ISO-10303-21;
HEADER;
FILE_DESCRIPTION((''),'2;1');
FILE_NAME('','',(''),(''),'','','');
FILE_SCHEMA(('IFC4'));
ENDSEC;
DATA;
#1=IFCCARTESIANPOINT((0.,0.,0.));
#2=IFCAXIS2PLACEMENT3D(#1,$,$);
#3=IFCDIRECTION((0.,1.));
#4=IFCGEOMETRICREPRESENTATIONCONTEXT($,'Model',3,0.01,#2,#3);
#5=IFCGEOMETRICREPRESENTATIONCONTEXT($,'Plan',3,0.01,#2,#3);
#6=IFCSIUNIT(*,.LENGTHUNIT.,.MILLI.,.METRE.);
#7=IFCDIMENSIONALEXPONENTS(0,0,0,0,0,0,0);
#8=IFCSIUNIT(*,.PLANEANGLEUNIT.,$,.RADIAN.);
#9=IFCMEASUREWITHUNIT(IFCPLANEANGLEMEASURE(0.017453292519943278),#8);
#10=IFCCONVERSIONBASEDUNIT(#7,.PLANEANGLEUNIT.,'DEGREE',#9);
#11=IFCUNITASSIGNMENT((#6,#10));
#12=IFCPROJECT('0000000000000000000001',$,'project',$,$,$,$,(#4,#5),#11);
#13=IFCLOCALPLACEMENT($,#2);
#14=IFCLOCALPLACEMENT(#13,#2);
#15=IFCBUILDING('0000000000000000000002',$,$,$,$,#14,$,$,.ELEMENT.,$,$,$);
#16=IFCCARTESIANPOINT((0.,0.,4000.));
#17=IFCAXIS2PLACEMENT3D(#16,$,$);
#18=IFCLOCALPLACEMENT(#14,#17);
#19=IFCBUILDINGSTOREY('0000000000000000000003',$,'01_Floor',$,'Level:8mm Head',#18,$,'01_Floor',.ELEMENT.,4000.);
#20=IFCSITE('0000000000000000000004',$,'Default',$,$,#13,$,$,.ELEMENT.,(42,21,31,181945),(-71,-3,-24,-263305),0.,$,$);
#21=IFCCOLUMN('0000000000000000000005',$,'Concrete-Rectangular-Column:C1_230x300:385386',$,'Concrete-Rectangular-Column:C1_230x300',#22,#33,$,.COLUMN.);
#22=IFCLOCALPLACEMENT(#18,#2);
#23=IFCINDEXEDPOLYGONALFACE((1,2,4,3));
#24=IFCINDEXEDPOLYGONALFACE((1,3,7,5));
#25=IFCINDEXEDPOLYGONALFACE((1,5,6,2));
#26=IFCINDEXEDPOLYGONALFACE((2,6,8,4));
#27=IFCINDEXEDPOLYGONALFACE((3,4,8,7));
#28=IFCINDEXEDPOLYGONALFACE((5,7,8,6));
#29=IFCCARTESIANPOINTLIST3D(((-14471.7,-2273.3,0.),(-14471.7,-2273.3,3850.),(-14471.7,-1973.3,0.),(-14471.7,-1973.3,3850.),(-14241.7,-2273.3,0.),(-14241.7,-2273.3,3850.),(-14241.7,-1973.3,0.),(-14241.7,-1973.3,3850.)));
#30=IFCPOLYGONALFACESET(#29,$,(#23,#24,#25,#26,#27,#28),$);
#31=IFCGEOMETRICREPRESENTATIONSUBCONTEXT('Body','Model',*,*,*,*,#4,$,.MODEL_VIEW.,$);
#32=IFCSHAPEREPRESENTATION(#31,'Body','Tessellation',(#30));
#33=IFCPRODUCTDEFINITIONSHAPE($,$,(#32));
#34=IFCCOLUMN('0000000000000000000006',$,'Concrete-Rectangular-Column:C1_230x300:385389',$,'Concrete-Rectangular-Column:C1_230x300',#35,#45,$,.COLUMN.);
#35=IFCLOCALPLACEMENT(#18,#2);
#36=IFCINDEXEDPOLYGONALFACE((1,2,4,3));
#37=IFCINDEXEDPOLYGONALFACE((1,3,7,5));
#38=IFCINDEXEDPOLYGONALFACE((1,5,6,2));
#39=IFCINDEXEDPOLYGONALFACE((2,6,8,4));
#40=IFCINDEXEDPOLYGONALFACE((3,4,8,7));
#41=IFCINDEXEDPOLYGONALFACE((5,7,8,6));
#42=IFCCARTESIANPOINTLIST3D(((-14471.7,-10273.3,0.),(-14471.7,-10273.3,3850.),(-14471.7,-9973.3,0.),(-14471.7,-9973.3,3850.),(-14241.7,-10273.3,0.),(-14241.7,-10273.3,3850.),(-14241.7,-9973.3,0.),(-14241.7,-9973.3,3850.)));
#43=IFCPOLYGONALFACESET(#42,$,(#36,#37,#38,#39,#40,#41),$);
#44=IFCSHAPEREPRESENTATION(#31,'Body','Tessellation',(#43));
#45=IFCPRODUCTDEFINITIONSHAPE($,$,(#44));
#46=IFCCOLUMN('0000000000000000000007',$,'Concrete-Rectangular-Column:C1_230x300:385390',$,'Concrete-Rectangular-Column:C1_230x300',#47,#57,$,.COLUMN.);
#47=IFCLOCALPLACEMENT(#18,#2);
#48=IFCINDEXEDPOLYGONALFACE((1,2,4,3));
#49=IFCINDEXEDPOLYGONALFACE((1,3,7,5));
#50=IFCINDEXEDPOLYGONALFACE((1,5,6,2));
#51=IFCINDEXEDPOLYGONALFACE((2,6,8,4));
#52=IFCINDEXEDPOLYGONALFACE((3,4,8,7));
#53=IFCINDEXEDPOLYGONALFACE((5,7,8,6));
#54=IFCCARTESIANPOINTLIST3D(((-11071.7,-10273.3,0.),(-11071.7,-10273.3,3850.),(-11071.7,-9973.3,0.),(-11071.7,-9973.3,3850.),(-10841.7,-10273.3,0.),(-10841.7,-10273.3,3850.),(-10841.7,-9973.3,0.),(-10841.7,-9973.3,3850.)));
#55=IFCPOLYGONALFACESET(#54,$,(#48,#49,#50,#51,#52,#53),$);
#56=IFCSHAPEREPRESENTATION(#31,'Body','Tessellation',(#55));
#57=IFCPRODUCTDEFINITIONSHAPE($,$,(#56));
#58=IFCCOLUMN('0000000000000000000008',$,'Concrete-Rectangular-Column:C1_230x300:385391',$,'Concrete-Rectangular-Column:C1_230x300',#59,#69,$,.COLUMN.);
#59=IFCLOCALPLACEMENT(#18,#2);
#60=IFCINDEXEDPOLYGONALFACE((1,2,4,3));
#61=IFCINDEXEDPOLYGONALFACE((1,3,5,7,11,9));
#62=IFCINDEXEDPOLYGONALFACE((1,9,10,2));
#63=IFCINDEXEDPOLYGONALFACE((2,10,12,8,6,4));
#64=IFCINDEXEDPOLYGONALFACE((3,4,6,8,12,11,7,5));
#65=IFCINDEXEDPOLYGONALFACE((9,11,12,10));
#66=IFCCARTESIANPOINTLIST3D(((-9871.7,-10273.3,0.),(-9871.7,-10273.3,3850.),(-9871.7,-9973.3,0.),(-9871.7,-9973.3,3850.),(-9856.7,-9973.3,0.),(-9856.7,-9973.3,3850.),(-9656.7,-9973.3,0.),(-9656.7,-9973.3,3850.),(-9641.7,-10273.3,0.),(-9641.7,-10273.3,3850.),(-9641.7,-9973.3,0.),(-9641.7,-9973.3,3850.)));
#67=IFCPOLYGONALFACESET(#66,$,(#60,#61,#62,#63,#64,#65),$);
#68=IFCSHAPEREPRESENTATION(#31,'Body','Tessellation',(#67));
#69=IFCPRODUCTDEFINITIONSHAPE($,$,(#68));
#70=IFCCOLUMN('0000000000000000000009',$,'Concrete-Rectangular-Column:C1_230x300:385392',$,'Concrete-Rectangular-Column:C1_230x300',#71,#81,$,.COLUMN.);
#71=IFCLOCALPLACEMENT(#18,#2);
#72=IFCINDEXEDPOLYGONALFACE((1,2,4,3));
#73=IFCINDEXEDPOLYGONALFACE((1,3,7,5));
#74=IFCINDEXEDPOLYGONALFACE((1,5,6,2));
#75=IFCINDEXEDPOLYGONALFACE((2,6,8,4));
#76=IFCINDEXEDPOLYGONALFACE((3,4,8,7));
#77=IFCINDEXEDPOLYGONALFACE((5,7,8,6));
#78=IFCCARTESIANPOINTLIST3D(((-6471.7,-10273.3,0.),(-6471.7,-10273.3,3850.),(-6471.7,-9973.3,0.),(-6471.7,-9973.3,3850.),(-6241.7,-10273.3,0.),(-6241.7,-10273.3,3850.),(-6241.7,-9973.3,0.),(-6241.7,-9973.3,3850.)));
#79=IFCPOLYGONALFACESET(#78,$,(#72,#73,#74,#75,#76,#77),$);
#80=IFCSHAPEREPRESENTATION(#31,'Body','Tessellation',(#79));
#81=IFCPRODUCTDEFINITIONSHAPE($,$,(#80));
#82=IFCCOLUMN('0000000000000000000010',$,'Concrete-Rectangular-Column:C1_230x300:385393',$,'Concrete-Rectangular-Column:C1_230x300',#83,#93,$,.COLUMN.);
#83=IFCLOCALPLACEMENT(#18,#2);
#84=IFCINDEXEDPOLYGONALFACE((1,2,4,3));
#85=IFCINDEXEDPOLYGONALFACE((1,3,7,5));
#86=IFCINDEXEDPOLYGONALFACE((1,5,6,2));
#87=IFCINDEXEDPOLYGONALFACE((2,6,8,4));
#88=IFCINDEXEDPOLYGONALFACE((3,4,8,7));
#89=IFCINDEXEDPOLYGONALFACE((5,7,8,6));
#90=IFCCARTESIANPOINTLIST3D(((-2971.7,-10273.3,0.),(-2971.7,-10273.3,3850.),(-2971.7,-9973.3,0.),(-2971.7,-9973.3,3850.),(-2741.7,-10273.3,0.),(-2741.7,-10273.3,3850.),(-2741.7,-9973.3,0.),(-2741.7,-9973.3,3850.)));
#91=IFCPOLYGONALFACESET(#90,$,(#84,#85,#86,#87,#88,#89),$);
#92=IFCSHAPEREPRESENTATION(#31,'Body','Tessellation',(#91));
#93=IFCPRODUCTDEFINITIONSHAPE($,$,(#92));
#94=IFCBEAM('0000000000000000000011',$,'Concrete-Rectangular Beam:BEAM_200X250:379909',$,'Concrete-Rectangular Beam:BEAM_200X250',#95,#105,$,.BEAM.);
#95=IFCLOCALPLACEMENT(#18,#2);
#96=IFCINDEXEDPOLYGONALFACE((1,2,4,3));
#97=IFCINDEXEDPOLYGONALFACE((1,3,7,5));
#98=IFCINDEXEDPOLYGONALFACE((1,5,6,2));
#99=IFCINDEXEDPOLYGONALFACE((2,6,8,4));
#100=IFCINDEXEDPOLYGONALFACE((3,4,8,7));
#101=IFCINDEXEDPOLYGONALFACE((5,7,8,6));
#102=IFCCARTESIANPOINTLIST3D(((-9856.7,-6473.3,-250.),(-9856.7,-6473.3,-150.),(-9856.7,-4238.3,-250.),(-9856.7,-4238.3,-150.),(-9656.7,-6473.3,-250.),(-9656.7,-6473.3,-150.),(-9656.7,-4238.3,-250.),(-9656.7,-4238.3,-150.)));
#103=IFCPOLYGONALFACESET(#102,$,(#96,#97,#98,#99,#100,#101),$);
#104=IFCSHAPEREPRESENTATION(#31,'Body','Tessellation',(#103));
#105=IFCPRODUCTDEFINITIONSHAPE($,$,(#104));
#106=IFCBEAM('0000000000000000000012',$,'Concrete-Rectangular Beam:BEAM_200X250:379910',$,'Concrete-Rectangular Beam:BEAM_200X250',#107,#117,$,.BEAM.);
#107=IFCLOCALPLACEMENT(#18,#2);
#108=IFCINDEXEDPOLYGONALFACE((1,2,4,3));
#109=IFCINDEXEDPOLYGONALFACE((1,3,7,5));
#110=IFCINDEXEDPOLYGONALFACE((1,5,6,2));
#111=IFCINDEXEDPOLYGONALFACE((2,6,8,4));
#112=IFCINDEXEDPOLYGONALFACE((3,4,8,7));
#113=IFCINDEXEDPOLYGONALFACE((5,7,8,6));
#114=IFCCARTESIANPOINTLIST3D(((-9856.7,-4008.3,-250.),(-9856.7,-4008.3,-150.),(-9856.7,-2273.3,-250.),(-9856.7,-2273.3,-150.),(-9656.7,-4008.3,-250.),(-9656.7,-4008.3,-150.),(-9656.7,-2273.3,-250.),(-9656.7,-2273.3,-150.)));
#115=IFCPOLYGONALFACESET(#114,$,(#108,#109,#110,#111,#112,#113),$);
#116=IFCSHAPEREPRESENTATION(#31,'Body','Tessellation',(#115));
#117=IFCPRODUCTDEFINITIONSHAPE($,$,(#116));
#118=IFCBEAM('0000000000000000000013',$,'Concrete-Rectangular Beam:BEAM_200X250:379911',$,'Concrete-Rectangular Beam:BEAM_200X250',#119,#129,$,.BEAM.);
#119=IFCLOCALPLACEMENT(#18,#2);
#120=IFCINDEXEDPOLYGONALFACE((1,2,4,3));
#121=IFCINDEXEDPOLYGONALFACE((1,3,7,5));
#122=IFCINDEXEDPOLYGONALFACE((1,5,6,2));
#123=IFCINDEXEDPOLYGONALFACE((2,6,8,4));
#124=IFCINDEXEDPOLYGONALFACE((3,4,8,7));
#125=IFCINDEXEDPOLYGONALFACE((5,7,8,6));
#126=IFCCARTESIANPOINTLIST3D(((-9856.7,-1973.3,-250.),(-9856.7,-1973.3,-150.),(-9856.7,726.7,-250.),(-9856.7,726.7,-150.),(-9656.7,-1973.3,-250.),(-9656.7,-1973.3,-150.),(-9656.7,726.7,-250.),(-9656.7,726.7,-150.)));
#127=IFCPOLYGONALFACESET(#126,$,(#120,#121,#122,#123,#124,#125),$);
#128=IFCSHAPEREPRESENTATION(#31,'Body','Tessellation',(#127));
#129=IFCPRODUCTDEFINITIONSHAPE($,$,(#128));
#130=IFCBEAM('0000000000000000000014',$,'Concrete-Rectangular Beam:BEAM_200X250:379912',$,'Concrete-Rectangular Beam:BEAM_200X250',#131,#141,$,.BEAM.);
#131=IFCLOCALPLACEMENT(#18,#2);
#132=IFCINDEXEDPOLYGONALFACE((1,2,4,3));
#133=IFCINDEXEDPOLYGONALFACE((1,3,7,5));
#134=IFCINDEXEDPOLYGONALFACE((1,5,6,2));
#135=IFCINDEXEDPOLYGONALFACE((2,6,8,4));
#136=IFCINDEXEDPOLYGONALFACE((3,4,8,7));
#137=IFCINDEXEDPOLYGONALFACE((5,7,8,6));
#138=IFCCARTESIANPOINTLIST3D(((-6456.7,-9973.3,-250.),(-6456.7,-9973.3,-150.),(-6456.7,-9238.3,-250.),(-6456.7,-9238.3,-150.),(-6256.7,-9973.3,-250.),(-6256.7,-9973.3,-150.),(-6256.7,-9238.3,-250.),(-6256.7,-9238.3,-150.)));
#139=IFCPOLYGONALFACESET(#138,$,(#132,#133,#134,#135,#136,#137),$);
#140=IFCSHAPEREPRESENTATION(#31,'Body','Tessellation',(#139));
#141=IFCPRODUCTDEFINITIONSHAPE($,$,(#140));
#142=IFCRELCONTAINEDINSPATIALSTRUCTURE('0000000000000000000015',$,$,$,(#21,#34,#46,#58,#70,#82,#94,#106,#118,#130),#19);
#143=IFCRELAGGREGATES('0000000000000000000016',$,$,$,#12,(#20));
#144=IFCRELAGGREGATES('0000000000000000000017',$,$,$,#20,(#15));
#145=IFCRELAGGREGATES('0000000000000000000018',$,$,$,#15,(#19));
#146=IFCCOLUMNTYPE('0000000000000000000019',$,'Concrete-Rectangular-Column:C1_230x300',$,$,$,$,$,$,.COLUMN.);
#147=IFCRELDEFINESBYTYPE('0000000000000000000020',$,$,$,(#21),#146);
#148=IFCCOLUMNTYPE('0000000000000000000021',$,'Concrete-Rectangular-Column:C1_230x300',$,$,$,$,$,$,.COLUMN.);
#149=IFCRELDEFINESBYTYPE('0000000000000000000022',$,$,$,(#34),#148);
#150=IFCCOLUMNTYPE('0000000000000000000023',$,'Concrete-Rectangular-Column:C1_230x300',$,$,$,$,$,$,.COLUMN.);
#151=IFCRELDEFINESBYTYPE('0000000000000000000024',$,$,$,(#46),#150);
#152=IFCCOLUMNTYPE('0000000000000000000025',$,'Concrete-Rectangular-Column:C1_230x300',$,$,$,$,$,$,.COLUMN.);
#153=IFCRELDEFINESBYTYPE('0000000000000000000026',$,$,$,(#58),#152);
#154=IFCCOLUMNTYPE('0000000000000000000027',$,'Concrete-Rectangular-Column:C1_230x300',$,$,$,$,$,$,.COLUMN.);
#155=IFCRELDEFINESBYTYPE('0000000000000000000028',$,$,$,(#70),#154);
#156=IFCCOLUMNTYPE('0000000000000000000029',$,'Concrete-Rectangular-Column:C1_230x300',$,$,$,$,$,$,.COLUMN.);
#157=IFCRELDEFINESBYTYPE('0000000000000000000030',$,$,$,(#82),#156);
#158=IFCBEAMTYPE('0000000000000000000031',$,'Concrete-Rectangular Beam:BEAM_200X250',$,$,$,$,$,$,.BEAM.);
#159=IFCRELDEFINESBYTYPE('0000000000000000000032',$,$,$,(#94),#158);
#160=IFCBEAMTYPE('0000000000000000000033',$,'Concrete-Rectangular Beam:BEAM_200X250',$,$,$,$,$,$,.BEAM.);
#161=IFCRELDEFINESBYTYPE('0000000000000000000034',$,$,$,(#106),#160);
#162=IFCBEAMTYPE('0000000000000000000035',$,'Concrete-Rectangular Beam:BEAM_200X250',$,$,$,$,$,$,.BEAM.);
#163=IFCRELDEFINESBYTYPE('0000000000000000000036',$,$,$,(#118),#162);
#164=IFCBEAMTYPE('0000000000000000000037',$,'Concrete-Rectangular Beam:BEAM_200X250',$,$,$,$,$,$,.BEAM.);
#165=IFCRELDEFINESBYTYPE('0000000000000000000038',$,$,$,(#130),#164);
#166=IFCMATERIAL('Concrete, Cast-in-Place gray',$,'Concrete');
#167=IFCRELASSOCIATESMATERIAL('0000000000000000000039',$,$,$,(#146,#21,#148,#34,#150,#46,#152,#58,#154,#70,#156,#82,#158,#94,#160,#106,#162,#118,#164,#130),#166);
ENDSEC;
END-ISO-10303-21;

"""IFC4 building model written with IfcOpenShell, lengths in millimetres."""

from ifc_helpers import new_model, entity, si_unit, converted_unit, direction, frame, origin, place, context, subcontext, project, spatial, indexed_curve, outline, extrude, source, transform, mapped, material, type_object, type_shapes, element, save


model = new_model("IFC4")

# Units and contexts
model_context = context("Model", 3, precision=0.01, world=origin(), true_north=direction((0.0, 1.0)))
plan_context = context("Plan", 3, precision=0.01, world=origin(), true_north=direction((0.0, 1.0)))
body_context = subcontext(model_context, "Body", "Model", "MODEL_VIEW")
ifc_project = project(units=[si_unit("LENGTHUNIT", "METRE", prefix="MILLI"), converted_unit("PLANEANGLEUNIT", "DEGREE", entity("IfcPlaneAngleMeasure", 0.017453292519943278), si_unit("PLANEANGLEUNIT", "RADIAN"), dimensions=[0, 0, 0, 0, 0, 0, 0])], contexts=[model_context, plan_context])

# Site, building, storey
site_placement = place(None, origin())
site = spatial("IfcSite", under=ifc_project, at=site_placement, Name="Default", CompositionType="ELEMENT", RefLatitude=(42, 21, 31, 181945), RefLongitude=(-71, -3, -24, -263305), RefElevation=0.0)
building_placement = place(site_placement, origin())
building = spatial("IfcBuilding", under=site, at=building_placement, CompositionType="ELEMENT")
storey_placement = place(building_placement, frame((0.0, 0.0, 4000.0)))
storey = spatial("IfcBuildingStorey", under=building, at=storey_placement, Name="01_Floor", ObjectType="Level:8mm Head", LongName="01_Floor", CompositionType="ELEMENT", Elevation=4000.0)

# Columns
ifc_material = material(Name="Concrete, Cast-in-Place gray", Category="Concrete")
column_type_1 = type_object("IfcColumnType", Name="Concrete-Rectangular-Column:C1_230x300", PredefinedType="COLUMN", material=ifc_material)
shared_shape_1 = source(origin(), body_context, "Body", "SweptSolid", [
    extrude(outline(indexed_curve([(-115.0, -150.0), (115.0, -150.0), (115.0, 150.0), (-115.0, 150.0), (-115.0, -150.0)], self_intersect=False)), frame((-14356.7, -2123.3, 4000.0), z_axis=(0.0, 0.0, 1.0), x_axis=(-1.0, 0.0, 0.0)), (0.0, 0.0, 1.0), 3850.0),
])
type_shapes(column_type_1, [shared_shape_1])
column_1_placement = place(storey_placement, frame((0.0, 0.0, -4000.0)))
element("IfcColumn", 1, at=column_1_placement, inside=storey, type_object=column_type_1, material=ifc_material, Name="Concrete-Rectangular-Column:C1_230x300:385386", ObjectType="Concrete-Rectangular-Column:C1_230x300", PredefinedType="COLUMN", context=body_context, shape_type="MappedRepresentation", body=[
    mapped(shared_shape_1, transform((0.0, 0.0, 0.0), scale=1.0)),
])
column_type_2 = type_object("IfcColumnType", Name="Concrete-Rectangular-Column:C1_230x300", PredefinedType="COLUMN", material=ifc_material)
shared_shape_2 = source(origin(), body_context, "Body", "SweptSolid", [
    extrude(outline(indexed_curve([(-115.0, -150.0), (115.0, -150.0), (115.0, 150.0), (-115.0, 150.0), (-115.0, -150.0)], self_intersect=False)), frame((-14356.7, -10123.3, 4000.0)), (0.0, 0.0, 1.0), 3850.0),
])
type_shapes(column_type_2, [shared_shape_2])
column_2_placement = place(storey_placement, frame((0.0, 0.0, -4000.0)))
element("IfcColumn", 2, at=column_2_placement, inside=storey, type_object=column_type_2, material=ifc_material, Name="Concrete-Rectangular-Column:C1_230x300:385389", ObjectType="Concrete-Rectangular-Column:C1_230x300", PredefinedType="COLUMN", context=body_context, shape_type="MappedRepresentation", body=[
    mapped(shared_shape_2, transform((0.0, 0.0, 0.0), scale=1.0)),
])
column_type_3 = type_object("IfcColumnType", Name="Concrete-Rectangular-Column:C1_230x300", PredefinedType="COLUMN", material=ifc_material)
shared_shape_3 = source(origin(), body_context, "Body", "SweptSolid", [
    extrude(outline(indexed_curve([(-115.0, -150.0), (115.0, -150.0), (115.0, 150.0), (-115.0, 150.0), (-115.0, -150.0)], self_intersect=False)), frame((-10956.7, -10123.3, 4000.0), z_axis=(0.0, 0.0, 1.0), x_axis=(-1.0, 0.0, 0.0)), (0.0, 0.0, 1.0), 3850.0),
])
type_shapes(column_type_3, [shared_shape_3])
column_3_placement = place(storey_placement, frame((0.0, 0.0, -4000.0)))
element("IfcColumn", 3, at=column_3_placement, inside=storey, type_object=column_type_3, material=ifc_material, Name="Concrete-Rectangular-Column:C1_230x300:385390", ObjectType="Concrete-Rectangular-Column:C1_230x300", PredefinedType="COLUMN", context=body_context, shape_type="MappedRepresentation", body=[
    mapped(shared_shape_3, transform((0.0, 0.0, 0.0), scale=1.0)),
])
column_type_4 = type_object("IfcColumnType", Name="Concrete-Rectangular-Column:C1_230x300", PredefinedType="COLUMN", material=ifc_material)
shared_shape_4 = source(origin(), body_context, "Body", "SweptSolid", [
    extrude(outline(indexed_curve([(-115.0, -200.0), (115.0, -200.0), (115.0, 100.0), (100.0, 100.0), (-100.0, 100.0), (-115.0, 100.0), (-115.0, -200.0)], self_intersect=False)), frame((-9756.7, -10073.3, 4000.0)), (0.0, 0.0, 1.0), 3850.0),
])
type_shapes(column_type_4, [shared_shape_4])
column_4_placement = place(storey_placement, frame((0.0, 0.0, -4000.0)))
element("IfcColumn", 4, at=column_4_placement, inside=storey, type_object=column_type_4, material=ifc_material, Name="Concrete-Rectangular-Column:C1_230x300:385391", ObjectType="Concrete-Rectangular-Column:C1_230x300", PredefinedType="COLUMN", context=body_context, shape_type="MappedRepresentation", body=[
    mapped(shared_shape_4, transform((0.0, 0.0, 0.0), scale=1.0)),
])
column_type_5 = type_object("IfcColumnType", Name="Concrete-Rectangular-Column:C1_230x300", PredefinedType="COLUMN", material=ifc_material)
shared_shape_5 = source(origin(), body_context, "Body", "SweptSolid", [
    extrude(outline(indexed_curve([(-115.0, -150.0), (115.0, -150.0), (115.0, 150.0), (-115.0, 150.0), (-115.0, -150.0)], self_intersect=False)), frame((-6356.7, -10123.3, 4000.0)), (0.0, 0.0, 1.0), 3850.0),
])
type_shapes(column_type_5, [shared_shape_5])
column_5_placement = place(storey_placement, frame((0.0, 0.0, -4000.0)))
element("IfcColumn", 5, at=column_5_placement, inside=storey, type_object=column_type_5, material=ifc_material, Name="Concrete-Rectangular-Column:C1_230x300:385392", ObjectType="Concrete-Rectangular-Column:C1_230x300", PredefinedType="COLUMN", context=body_context, shape_type="MappedRepresentation", body=[
    mapped(shared_shape_5, transform((0.0, 0.0, 0.0), scale=1.0)),
])
column_type_6 = type_object("IfcColumnType", Name="Concrete-Rectangular-Column:C1_230x300", PredefinedType="COLUMN", material=ifc_material)
shared_shape_6 = source(origin(), body_context, "Body", "SweptSolid", [
    extrude(outline(indexed_curve([(-115.0, -150.0), (115.0, -150.0), (115.0, 150.0), (-115.0, 150.0), (-115.0, -150.0)], self_intersect=False)), frame((-2856.7, -10123.3, 4000.0), z_axis=(0.0, 0.0, 1.0), x_axis=(-1.0, 0.0, 0.0)), (0.0, 0.0, 1.0), 3850.0),
])
type_shapes(column_type_6, [shared_shape_6])
column_6_placement = place(storey_placement, frame((0.0, 0.0, -4000.0)))
element("IfcColumn", 6, at=column_6_placement, inside=storey, type_object=column_type_6, material=ifc_material, Name="Concrete-Rectangular-Column:C1_230x300:385393", ObjectType="Concrete-Rectangular-Column:C1_230x300", PredefinedType="COLUMN", context=body_context, shape_type="MappedRepresentation", body=[
    mapped(shared_shape_6, transform((0.0, 0.0, 0.0), scale=1.0)),
])

# Beams
beam_type_1 = type_object("IfcBeamType", Name="Concrete-Rectangular Beam:BEAM_200X250", PredefinedType="BEAM", material=ifc_material)
shared_shape_7 = source(origin(), body_context, "Body", "SweptSolid", [
    extrude(outline(indexed_curve([(-100.0, -50.0), (100.0, -50.0), (100.0, 50.0), (-100.0, 50.0), (-100.0, -50.0)], self_intersect=False)), frame((-9756.7, -6473.3, 3800.0), z_axis=(0.0, 1.0, 0.0), x_axis=(-1.0, 0.0, 0.0)), (0.0, 0.0, 1.0), 2235.0),
])
type_shapes(beam_type_1, [shared_shape_7])
beam_1_placement = place(storey_placement, frame((0.0, 0.0, -4000.0)))
element("IfcBeam", 7, at=beam_1_placement, inside=storey, type_object=beam_type_1, material=ifc_material, Name="Concrete-Rectangular Beam:BEAM_200X250:379909", ObjectType="Concrete-Rectangular Beam:BEAM_200X250", PredefinedType="BEAM", context=body_context, shape_type="MappedRepresentation", body=[
    mapped(shared_shape_7, transform((0.0, 0.0, 0.0), scale=1.0)),
])
beam_type_2 = type_object("IfcBeamType", Name="Concrete-Rectangular Beam:BEAM_200X250", PredefinedType="BEAM", material=ifc_material)
shared_shape_8 = source(origin(), body_context, "Body", "SweptSolid", [
    extrude(outline(indexed_curve([(-100.0, -50.0), (100.0, -50.0), (100.0, 50.0), (-100.0, 50.0), (-100.0, -50.0)], self_intersect=False)), frame((-9756.7, -4008.3, 3800.0), z_axis=(0.0, 1.0, 0.0), x_axis=(-1.0, 0.0, 0.0)), (0.0, 0.0, 1.0), 1735.0),
])
type_shapes(beam_type_2, [shared_shape_8])
beam_2_placement = place(storey_placement, frame((0.0, 0.0, -4000.0)))
element("IfcBeam", 8, at=beam_2_placement, inside=storey, type_object=beam_type_2, material=ifc_material, Name="Concrete-Rectangular Beam:BEAM_200X250:379910", ObjectType="Concrete-Rectangular Beam:BEAM_200X250", PredefinedType="BEAM", context=body_context, shape_type="MappedRepresentation", body=[
    mapped(shared_shape_8, transform((0.0, 0.0, 0.0), scale=1.0)),
])
beam_type_3 = type_object("IfcBeamType", Name="Concrete-Rectangular Beam:BEAM_200X250", PredefinedType="BEAM", material=ifc_material)
shared_shape_9 = source(origin(), body_context, "Body", "SweptSolid", [
    extrude(outline(indexed_curve([(-100.0, -50.0), (100.0, -50.0), (100.0, 50.0), (-100.0, 50.0), (-100.0, -50.0)], self_intersect=False)), frame((-9756.7, -1973.3, 3800.0), z_axis=(0.0, 1.0, 0.0), x_axis=(-1.0, 0.0, 0.0)), (0.0, 0.0, 1.0), 2700.0),
])
type_shapes(beam_type_3, [shared_shape_9])
beam_3_placement = place(storey_placement, frame((0.0, 0.0, -4000.0)))
element("IfcBeam", 9, at=beam_3_placement, inside=storey, type_object=beam_type_3, material=ifc_material, Name="Concrete-Rectangular Beam:BEAM_200X250:379911", ObjectType="Concrete-Rectangular Beam:BEAM_200X250", PredefinedType="BEAM", context=body_context, shape_type="MappedRepresentation", body=[
    mapped(shared_shape_9, transform((0.0, 0.0, 0.0), scale=1.0)),
])
beam_type_4 = type_object("IfcBeamType", Name="Concrete-Rectangular Beam:BEAM_200X250", PredefinedType="BEAM", material=ifc_material)
shared_shape_10 = source(origin(), body_context, "Body", "SweptSolid", [
    extrude(outline(indexed_curve([(-100.0, -50.0), (100.0, -50.0), (100.0, 50.0), (-100.0, 50.0), (-100.0, -50.0)], self_intersect=False)), frame((-6356.7, -9973.3, 3800.0), z_axis=(0.0, 1.0, 0.0), x_axis=(-1.0, 0.0, 0.0)), (0.0, 0.0, 1.0), 735.0),
])
type_shapes(beam_type_4, [shared_shape_10])
beam_4_placement = place(storey_placement, frame((0.0, 0.0, -4000.0)))
element("IfcBeam", 10, at=beam_4_placement, inside=storey, type_object=beam_type_4, material=ifc_material, Name="Concrete-Rectangular Beam:BEAM_200X250:379912", ObjectType="Concrete-Rectangular Beam:BEAM_200X250", PredefinedType="BEAM", context=body_context, shape_type="MappedRepresentation", body=[
    mapped(shared_shape_10, transform((0.0, 0.0, 0.0), scale=1.0)),
])

save(model, "model.ifc")
